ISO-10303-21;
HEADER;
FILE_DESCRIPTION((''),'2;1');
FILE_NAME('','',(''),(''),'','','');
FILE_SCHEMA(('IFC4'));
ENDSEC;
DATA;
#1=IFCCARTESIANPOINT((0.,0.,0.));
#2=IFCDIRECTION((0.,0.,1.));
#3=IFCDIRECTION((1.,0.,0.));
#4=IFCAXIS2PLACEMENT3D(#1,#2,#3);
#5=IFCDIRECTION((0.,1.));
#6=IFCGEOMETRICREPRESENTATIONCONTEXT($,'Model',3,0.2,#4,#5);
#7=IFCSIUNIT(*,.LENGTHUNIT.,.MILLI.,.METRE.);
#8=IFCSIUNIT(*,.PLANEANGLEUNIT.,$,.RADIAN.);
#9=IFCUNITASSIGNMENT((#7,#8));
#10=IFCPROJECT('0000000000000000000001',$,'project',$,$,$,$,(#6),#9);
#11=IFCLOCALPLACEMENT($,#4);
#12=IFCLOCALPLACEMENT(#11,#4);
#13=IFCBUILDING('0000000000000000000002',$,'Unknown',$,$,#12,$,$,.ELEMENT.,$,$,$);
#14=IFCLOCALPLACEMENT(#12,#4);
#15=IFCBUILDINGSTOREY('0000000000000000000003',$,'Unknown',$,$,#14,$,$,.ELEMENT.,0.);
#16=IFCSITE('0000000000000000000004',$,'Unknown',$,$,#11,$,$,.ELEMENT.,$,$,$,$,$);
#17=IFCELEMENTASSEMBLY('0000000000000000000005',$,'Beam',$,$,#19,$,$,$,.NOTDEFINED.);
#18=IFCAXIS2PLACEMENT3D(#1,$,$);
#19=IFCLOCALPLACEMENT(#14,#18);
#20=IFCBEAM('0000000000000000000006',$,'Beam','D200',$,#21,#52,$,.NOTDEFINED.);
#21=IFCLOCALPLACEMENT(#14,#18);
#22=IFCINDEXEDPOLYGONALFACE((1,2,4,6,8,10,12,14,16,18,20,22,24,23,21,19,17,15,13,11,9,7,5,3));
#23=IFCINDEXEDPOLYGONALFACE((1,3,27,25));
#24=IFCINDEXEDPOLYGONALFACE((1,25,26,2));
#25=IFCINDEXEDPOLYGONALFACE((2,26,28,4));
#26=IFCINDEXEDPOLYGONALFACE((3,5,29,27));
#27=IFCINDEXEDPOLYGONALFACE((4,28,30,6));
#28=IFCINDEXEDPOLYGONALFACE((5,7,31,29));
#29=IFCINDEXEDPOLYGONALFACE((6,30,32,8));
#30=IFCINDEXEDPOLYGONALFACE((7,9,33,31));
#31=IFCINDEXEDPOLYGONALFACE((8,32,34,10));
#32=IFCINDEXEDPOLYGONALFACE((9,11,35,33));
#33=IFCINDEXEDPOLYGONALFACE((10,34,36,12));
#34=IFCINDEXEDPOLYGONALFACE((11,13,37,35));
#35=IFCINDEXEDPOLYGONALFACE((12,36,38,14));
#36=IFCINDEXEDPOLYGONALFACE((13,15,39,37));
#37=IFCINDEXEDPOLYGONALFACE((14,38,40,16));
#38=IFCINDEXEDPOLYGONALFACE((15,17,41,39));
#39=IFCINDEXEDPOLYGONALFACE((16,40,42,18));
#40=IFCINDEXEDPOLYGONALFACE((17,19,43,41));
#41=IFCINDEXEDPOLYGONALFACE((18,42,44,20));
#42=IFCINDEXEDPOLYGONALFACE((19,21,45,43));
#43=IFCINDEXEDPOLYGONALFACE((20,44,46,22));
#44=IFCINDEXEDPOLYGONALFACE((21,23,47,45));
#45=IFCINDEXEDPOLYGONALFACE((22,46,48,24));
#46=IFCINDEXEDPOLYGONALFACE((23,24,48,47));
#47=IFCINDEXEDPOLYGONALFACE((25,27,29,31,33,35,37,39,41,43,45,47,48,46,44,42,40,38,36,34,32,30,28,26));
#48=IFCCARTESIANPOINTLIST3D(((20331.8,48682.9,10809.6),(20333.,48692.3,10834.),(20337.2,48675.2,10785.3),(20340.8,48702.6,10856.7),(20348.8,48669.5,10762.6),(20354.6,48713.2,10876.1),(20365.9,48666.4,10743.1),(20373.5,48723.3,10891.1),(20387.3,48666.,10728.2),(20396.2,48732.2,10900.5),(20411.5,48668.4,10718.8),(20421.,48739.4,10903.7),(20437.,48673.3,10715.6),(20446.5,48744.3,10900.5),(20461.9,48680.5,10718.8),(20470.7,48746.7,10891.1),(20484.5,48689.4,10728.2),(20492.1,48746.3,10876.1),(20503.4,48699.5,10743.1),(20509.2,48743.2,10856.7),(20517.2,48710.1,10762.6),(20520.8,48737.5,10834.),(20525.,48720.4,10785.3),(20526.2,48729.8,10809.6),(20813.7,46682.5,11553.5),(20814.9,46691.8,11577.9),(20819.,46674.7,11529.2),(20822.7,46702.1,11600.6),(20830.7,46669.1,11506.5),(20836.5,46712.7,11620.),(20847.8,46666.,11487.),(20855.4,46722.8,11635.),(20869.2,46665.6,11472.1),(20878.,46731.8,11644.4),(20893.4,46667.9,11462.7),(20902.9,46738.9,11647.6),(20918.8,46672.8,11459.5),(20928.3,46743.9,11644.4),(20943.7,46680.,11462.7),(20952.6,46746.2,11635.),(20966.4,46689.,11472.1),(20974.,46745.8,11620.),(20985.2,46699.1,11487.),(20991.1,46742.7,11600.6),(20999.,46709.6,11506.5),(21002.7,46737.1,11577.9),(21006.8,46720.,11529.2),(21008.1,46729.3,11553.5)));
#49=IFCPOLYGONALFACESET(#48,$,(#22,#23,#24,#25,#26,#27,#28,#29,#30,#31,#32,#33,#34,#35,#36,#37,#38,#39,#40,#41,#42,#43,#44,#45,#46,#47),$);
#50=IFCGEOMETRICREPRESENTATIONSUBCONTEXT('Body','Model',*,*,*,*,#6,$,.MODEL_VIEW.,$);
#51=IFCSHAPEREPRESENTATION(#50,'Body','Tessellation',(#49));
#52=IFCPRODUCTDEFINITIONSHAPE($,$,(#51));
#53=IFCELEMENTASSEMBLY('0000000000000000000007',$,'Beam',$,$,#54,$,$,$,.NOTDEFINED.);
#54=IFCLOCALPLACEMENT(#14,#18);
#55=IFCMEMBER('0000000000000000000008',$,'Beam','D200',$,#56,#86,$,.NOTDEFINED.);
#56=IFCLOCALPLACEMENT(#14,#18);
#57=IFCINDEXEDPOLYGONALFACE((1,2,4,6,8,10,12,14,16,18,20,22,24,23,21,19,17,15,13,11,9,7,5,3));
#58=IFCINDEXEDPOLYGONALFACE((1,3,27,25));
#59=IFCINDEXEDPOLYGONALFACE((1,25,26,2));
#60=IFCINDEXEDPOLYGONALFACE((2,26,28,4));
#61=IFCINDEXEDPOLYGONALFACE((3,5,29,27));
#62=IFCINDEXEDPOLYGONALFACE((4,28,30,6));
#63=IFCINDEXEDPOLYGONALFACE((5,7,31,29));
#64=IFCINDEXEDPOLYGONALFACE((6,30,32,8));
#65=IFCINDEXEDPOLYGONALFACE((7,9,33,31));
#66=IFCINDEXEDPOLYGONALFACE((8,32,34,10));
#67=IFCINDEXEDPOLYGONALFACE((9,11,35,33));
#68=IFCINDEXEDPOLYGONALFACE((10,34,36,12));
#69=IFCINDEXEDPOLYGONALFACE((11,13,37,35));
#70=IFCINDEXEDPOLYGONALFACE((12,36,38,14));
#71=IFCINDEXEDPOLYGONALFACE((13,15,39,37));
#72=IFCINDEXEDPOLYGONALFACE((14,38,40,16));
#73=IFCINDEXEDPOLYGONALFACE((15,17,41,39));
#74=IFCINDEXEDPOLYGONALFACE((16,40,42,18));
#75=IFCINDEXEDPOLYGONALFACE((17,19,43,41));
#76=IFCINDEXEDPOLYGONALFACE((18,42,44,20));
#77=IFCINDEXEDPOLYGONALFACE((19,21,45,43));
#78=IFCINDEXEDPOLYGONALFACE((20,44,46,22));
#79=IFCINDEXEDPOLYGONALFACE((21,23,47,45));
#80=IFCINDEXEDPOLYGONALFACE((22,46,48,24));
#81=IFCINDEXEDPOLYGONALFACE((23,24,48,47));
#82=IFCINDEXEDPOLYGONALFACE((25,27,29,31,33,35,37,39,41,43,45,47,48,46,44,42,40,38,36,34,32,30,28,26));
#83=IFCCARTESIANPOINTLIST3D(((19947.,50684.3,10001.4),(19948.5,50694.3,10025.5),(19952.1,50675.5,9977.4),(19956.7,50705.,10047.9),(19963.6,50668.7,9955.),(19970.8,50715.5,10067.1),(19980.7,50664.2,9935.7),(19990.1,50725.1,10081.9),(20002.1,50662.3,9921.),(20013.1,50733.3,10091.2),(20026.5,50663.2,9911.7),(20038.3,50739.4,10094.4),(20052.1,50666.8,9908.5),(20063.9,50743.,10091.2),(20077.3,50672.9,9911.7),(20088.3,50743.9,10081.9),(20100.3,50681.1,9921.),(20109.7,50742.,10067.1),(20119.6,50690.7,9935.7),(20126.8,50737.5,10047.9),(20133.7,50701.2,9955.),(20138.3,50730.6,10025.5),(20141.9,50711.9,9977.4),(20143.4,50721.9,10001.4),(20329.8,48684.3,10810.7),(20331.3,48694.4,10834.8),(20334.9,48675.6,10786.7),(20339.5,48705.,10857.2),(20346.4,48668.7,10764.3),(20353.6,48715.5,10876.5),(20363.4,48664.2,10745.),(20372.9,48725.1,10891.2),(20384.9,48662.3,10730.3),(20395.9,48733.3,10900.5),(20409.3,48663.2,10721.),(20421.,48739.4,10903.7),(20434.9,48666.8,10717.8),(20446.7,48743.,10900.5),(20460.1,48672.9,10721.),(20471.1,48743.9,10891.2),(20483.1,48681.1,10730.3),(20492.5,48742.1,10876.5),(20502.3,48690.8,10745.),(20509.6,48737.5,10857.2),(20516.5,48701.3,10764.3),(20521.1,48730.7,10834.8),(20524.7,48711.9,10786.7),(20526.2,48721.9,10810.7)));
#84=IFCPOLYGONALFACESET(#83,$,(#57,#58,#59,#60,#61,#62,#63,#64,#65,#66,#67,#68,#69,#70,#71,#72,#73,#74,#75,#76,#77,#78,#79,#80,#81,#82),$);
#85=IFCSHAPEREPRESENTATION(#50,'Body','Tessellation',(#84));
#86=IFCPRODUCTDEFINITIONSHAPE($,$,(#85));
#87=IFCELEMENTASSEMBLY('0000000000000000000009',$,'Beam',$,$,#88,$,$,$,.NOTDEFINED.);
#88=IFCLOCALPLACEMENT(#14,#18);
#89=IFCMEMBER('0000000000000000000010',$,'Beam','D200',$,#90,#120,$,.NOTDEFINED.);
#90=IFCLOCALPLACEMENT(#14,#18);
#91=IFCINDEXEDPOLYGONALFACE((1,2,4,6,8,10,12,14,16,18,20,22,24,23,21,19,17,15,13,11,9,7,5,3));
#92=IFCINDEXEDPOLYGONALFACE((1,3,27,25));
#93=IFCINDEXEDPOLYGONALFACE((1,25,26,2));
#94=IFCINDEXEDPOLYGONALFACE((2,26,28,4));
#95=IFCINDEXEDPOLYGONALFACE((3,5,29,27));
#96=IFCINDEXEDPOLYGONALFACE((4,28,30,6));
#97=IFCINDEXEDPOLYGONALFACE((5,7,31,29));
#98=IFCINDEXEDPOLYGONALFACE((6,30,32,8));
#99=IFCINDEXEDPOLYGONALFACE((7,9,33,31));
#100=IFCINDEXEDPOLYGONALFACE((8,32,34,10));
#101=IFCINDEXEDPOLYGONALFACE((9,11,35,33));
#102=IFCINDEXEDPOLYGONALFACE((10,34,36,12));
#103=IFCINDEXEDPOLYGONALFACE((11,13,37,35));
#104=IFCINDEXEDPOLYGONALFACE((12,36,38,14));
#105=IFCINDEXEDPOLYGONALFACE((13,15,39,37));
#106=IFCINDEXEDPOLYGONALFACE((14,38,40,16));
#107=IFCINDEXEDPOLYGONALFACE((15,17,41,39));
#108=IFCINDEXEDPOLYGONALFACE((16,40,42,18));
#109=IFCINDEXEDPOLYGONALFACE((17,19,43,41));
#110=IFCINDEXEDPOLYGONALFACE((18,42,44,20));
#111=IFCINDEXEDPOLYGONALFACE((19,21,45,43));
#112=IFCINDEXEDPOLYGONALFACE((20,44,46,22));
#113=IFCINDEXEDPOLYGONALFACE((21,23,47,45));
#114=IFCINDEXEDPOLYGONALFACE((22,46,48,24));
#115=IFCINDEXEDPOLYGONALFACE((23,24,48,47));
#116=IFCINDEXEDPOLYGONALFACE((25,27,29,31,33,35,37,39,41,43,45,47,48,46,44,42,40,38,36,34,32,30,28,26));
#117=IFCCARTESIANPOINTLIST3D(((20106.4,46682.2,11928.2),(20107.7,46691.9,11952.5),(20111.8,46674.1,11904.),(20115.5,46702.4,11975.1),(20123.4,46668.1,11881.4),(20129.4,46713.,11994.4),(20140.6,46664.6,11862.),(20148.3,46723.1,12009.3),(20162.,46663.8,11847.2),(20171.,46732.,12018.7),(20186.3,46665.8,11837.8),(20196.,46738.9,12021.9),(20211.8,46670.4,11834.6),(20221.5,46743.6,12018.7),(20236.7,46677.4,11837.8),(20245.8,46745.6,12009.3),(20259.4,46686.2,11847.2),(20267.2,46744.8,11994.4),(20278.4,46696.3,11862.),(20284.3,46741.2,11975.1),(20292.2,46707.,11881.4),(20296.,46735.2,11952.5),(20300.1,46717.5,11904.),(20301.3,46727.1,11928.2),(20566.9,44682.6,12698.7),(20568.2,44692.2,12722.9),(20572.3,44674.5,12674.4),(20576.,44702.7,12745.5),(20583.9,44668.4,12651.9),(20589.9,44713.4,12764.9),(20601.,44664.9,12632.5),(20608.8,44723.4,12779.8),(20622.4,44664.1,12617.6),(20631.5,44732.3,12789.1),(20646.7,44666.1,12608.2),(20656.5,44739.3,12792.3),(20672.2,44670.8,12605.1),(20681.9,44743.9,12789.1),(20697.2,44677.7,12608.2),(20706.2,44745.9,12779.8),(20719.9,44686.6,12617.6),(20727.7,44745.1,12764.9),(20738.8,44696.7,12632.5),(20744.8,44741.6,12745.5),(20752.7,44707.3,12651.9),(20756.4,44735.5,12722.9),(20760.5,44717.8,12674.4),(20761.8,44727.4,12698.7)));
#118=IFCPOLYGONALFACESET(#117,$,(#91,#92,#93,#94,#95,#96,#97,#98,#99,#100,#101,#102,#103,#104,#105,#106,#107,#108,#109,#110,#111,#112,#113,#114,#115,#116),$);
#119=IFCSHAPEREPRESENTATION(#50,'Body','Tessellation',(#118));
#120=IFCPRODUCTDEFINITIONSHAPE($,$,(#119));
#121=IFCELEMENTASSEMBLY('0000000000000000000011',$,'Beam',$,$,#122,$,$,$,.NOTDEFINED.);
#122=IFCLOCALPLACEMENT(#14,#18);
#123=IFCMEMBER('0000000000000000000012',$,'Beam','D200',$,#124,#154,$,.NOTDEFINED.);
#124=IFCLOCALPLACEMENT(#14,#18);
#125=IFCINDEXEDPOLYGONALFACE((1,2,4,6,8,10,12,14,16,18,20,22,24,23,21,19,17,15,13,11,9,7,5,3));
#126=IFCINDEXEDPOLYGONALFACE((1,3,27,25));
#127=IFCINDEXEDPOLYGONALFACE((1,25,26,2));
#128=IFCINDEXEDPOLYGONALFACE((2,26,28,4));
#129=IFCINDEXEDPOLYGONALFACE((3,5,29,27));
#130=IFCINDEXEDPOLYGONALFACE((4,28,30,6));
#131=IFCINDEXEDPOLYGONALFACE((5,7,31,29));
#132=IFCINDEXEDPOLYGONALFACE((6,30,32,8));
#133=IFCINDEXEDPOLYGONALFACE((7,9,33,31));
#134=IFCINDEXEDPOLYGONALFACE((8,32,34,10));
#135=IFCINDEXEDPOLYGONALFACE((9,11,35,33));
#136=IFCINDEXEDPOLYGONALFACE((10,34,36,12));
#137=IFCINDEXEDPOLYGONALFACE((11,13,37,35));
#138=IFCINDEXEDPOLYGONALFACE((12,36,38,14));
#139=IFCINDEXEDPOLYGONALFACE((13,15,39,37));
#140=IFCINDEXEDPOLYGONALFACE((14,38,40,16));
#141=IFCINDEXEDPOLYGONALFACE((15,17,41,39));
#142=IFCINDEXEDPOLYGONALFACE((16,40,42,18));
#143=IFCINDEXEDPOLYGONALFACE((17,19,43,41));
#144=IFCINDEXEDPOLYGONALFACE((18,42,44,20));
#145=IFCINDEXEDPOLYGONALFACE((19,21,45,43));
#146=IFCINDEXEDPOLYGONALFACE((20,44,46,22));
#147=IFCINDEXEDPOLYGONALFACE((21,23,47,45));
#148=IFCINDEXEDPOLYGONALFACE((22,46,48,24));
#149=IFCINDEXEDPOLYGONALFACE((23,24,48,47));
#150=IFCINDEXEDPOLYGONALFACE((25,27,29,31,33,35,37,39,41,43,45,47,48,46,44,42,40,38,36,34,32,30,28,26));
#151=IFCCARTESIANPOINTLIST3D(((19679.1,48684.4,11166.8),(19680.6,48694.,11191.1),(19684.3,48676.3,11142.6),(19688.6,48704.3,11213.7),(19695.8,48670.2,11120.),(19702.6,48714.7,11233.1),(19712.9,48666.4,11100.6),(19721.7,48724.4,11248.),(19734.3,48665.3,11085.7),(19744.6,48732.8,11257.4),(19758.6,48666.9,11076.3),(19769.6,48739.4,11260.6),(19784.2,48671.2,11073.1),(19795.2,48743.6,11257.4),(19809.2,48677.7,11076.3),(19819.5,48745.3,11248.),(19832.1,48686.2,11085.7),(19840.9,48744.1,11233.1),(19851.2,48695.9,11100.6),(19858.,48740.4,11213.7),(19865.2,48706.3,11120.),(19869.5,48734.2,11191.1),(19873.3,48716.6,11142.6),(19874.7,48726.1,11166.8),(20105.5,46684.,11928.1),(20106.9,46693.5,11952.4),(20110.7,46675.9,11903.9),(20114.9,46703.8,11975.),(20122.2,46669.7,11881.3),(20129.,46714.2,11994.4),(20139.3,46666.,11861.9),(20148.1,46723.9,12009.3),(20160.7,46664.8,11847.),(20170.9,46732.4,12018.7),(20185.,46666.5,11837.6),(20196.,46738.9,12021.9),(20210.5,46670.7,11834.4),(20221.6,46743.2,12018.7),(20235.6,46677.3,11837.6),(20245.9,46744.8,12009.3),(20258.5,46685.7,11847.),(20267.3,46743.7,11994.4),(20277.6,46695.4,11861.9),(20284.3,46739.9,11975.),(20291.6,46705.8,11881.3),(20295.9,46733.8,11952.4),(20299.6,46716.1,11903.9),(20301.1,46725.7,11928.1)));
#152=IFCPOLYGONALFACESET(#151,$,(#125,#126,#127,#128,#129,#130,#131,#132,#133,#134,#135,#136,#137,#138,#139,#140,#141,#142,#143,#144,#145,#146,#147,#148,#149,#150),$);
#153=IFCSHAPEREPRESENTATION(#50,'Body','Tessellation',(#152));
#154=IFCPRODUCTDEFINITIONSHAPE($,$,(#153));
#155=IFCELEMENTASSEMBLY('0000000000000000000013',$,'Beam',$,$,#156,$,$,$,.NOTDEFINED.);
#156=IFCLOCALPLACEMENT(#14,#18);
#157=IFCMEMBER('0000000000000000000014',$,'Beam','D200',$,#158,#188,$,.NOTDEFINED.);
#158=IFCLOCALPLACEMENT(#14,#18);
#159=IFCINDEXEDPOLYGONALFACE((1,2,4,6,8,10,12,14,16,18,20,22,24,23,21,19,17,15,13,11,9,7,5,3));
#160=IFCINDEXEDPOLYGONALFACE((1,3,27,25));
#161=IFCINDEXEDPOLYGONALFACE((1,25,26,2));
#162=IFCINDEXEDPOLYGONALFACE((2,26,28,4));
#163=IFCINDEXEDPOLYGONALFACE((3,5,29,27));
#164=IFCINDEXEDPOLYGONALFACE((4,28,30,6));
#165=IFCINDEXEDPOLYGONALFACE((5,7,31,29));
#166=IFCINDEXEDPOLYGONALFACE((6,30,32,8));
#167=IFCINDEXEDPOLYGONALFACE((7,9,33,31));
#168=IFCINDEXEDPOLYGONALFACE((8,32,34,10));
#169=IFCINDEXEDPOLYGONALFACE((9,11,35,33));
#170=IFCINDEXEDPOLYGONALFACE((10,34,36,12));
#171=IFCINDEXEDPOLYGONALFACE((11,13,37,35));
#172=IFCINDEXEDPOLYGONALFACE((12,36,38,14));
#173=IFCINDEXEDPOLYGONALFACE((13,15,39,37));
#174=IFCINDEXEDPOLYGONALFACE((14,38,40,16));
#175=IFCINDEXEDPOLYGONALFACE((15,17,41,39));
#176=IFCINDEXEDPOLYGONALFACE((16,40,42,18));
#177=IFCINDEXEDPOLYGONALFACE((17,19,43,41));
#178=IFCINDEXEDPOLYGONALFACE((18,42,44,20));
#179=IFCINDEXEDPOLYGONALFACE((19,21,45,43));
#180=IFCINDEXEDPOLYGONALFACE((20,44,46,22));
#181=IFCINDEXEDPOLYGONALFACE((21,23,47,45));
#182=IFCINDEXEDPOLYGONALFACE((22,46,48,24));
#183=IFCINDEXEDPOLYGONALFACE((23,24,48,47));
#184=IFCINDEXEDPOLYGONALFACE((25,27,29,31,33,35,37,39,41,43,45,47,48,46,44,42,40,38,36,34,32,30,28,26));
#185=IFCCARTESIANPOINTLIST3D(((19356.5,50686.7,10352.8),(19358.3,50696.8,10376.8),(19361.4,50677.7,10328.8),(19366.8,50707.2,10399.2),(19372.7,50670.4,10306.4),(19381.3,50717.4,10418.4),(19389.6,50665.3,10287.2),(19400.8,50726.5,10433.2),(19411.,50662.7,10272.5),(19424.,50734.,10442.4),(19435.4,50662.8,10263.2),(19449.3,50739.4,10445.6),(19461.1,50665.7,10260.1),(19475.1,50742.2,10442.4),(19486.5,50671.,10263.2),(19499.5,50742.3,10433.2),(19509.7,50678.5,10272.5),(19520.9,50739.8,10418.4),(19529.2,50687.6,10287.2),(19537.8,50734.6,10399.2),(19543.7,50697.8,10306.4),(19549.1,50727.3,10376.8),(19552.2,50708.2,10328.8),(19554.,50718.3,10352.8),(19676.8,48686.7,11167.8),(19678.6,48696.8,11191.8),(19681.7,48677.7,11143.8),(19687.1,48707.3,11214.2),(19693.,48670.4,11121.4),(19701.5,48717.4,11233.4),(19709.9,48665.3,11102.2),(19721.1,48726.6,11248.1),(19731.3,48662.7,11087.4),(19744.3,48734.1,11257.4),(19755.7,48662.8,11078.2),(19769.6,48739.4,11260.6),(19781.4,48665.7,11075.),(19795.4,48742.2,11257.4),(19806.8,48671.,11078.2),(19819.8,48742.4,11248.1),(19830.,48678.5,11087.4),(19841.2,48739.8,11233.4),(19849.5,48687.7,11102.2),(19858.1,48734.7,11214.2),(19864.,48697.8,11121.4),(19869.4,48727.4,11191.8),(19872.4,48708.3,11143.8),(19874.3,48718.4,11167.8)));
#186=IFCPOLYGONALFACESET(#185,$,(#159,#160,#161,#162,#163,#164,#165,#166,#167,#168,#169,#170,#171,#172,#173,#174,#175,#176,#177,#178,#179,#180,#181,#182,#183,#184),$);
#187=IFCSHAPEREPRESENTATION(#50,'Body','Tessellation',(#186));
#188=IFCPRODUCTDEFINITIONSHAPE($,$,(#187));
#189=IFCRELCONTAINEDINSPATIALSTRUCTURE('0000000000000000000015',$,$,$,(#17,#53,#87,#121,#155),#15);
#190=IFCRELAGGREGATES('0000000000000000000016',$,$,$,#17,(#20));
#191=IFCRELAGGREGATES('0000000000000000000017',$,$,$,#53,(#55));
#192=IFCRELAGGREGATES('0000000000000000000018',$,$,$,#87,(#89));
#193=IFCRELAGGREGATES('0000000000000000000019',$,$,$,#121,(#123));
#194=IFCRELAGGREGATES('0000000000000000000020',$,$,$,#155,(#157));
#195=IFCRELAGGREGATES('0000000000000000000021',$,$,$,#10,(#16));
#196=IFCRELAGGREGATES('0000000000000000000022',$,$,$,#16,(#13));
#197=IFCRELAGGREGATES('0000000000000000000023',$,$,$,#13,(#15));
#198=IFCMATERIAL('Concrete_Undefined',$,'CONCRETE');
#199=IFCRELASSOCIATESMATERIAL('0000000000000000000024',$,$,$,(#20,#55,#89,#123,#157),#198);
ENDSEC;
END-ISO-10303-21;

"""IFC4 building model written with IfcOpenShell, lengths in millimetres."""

from ifc_helpers import new_model, si_unit, direction, frame, origin_with_axes, place, context, subcontext, project, spatial, line, indexed_curve, outline, extrude, material, element, aggregate, save


model = new_model("IFC4")

# Units and contexts
model_context = context("Model", 3, precision=0.2, world=origin_with_axes(), true_north=direction((0.0, 1.0)))
body_context = subcontext(model_context, "Body", "Model", "MODEL_VIEW")
ifc_project = project(units=[si_unit("LENGTHUNIT", "METRE", prefix="MILLI"), si_unit("PLANEANGLEUNIT", "RADIAN")], contexts=[model_context])

# Site, building, storey
site_placement = place(None, origin_with_axes())
site = spatial("IfcSite", under=ifc_project, at=site_placement, Name="Unknown", CompositionType="ELEMENT")
building_placement = place(site_placement, origin_with_axes())
building = spatial("IfcBuilding", under=site, at=building_placement, Name="Unknown", CompositionType="ELEMENT")
storey_placement = place(building_placement, origin_with_axes())
storey = spatial("IfcBuildingStorey", under=building, at=storey_placement, Name="Unknown", CompositionType="ELEMENT", Elevation=0.0)

# Element assembly, beam
assembly_1_placement = place(storey_placement, frame((20429.0, 48706.3, 10809.6), z_axis=(-0.972193, -0.23418, 0.0), x_axis=(0.220229, -0.914277, 0.339995)))
assembly_1 = element("IfcElementAssembly", 1, at=assembly_1_placement, inside=storey, Name="Beam", PredefinedType="NOTDEFINED")
ifc_material = material(Name="Concrete_Undefined", Category="CONCRETE")
beam_1_placement = place(assembly_1_placement, origin_with_axes())
beam_1 = element("IfcBeam", 2, at=beam_1_placement, material=ifc_material, Name="Beam", Description="D200", PredefinedType="NOTDEFINED", context=body_context, shape_type="SolidModel", body=[
    extrude(outline(indexed_curve([(100.0, 0.0), (96.6, 25.9), (86.6, 50.0), (70.7, 70.7), (50.0, 86.6), (25.9, 96.6), (0.0, 100.0), (-25.9, 96.6), (-50.0, 86.6), (-70.7, 70.7), (-86.6, 50.0), (-96.6, 25.9), (-100.0, 0.0), (-96.6, -25.9), (-86.6, -50.0), (-70.7, -70.7), (-50.0, -86.6), (-25.9, -96.6), (0.0, -100.0), (25.9, -96.6), (50.0, -86.6), (70.7, -70.7), (86.6, -50.0), (96.6, -25.9)], segments=[line(1, 2, 3, 4, 5, 6, 7, 8, 9, 10, 11, 12, 13, 14, 15, 16, 17, 18, 19, 20, 21, 22, 23, 24, 1)])), frame((0.0, 0.0, 0.0), z_axis=(-1.0, 0.0, 0.0), x_axis=(0.0, 0.0, 1.0)), (0.0, 0.0, -1.0), 2188.0),
])
aggregate(assembly_1, [beam_1])

# Element assemblies, members
assembly_2_placement = place(storey_placement, frame((20045.2, 50703.1, 10001.4), z_axis=(-0.982173, -0.187981, 0.0), x_axis=(0.174689, -0.912725, 0.369346)))
assembly_2 = element("IfcElementAssembly", 3, at=assembly_2_placement, inside=storey, Name="Beam", PredefinedType="NOTDEFINED")
member_1_placement = place(assembly_2_placement, origin_with_axes())
member_1 = element("IfcMember", 4, at=member_1_placement, material=ifc_material, Name="Beam", Description="D200", PredefinedType="NOTDEFINED", context=body_context, shape_type="SolidModel", body=[
    extrude(outline(indexed_curve([(100.0, 0.0), (96.6, 25.9), (86.6, 50.0), (70.7, 70.7), (50.0, 86.6), (25.9, 96.6), (0.0, 100.0), (-25.9, 96.6), (-50.0, 86.6), (-70.7, 70.7), (-86.6, 50.0), (-96.6, 25.9), (-100.0, 0.0), (-96.6, -25.9), (-86.6, -50.0), (-70.7, -70.7), (-50.0, -86.6), (-25.9, -96.6), (0.0, -100.0), (25.9, -96.6), (50.0, -86.6), (70.7, -70.7), (86.6, -50.0), (96.6, -25.9)], segments=[line(1, 2, 3, 4, 5, 6, 7, 8, 9, 10, 11, 12, 13, 14, 15, 16, 17, 18, 19, 20, 21, 22, 23, 24, 1)])), frame((0.0, 0.0, 0.0), z_axis=(-1.0, 0.0, 0.0), x_axis=(0.0, 0.0, 1.0)), (0.0, 0.0, -1.0), 2191.2),
])
aggregate(assembly_2, [member_1])
assembly_3_placement = place(storey_placement, frame((20203.9, 46704.7, 11928.2), z_axis=(-0.974499, -0.224392, 0.0), x_axis=(0.210073, -0.912315, 0.351498)))
assembly_3 = element("IfcElementAssembly", 5, at=assembly_3_placement, inside=storey, Name="Beam", PredefinedType="NOTDEFINED")
member_2_placement = place(assembly_3_placement, origin_with_axes())
member_2 = element("IfcMember", 6, at=member_2_placement, material=ifc_material, Name="Beam", Description="D200", PredefinedType="NOTDEFINED", context=body_context, shape_type="SolidModel", body=[
    extrude(outline(indexed_curve([(100.0, 0.0), (96.6, 25.9), (86.6, 50.0), (70.7, 70.7), (50.0, 86.6), (25.9, 96.6), (0.0, 100.0), (-25.9, 96.6), (-50.0, 86.6), (-70.7, 70.7), (-86.6, 50.0), (-96.6, 25.9), (-100.0, 0.0), (-96.6, -25.9), (-86.6, -50.0), (-70.7, -70.7), (-50.0, -86.6), (-25.9, -96.6), (0.0, -100.0), (25.9, -96.6), (50.0, -86.6), (70.7, -70.7), (86.6, -50.0), (96.6, -25.9)], segments=[line(1, 2, 3, 4, 5, 6, 7, 8, 9, 10, 11, 12, 13, 14, 15, 16, 17, 18, 19, 20, 21, 22, 23, 24, 1)])), frame((0.0, 0.0, 0.0), z_axis=(-1.0, 0.0, 0.0), x_axis=(0.0, 0.0, 1.0)), (0.0, 0.0, -1.0), 2191.9),
])
aggregate(assembly_3, [member_2])
assembly_4_placement = place(storey_placement, frame((19776.9, 48705.3, 11166.8), z_axis=(-0.978034, -0.208448, 0.0), x_axis=(0.195355, -0.916601, 0.348824)))
assembly_4 = element("IfcElementAssembly", 7, at=assembly_4_placement, inside=storey, Name="Beam", PredefinedType="NOTDEFINED")
member_3_placement = place(assembly_4_placement, origin_with_axes())
member_3 = element("IfcMember", 8, at=member_3_placement, material=ifc_material, Name="Beam", Description="D200", PredefinedType="NOTDEFINED", context=body_context, shape_type="SolidModel", body=[
    extrude(outline(indexed_curve([(100.0, 0.0), (96.6, 25.9), (86.6, 50.0), (70.7, 70.7), (50.0, 86.6), (25.9, 96.6), (0.0, 100.0), (-25.9, 96.6), (-50.0, 86.6), (-70.7, 70.7), (-86.6, 50.0), (-96.6, 25.9), (-100.0, 0.0), (-96.6, -25.9), (-86.6, -50.0), (-70.7, -70.7), (-50.0, -86.6), (-25.9, -96.6), (0.0, -100.0), (25.9, -96.6), (50.0, -86.6), (70.7, -70.7), (86.6, -50.0), (96.6, -25.9)], segments=[line(1, 2, 3, 4, 5, 6, 7, 8, 9, 10, 11, 12, 13, 14, 15, 16, 17, 18, 19, 20, 21, 22, 23, 24, 1)])), frame((0.0, 0.0, 0.0), z_axis=(-1.0, 0.0, 0.0), x_axis=(0.0, 0.0, 1.0)), (0.0, 0.0, -1.0), 2182.5),
])
aggregate(assembly_4, [member_3])
assembly_5_placement = place(storey_placement, frame((19455.2, 50702.5, 10352.8), z_axis=(-0.987417, -0.158136, 0.0), x_axis=(0.146706, -0.916047, 0.373277)))
assembly_5 = element("IfcElementAssembly", 9, at=assembly_5_placement, inside=storey, Name="Beam", PredefinedType="NOTDEFINED")
member_4_placement = place(assembly_5_placement, origin_with_axes())
member_4 = element("IfcMember", 10, at=member_4_placement, material=ifc_material, Name="Beam", Description="D200", PredefinedType="NOTDEFINED", context=body_context, shape_type="SolidModel", body=[
    extrude(outline(indexed_curve([(100.0, 0.0), (96.6, 25.9), (86.6, 50.0), (70.7, 70.7), (50.0, 86.6), (25.9, 96.6), (0.0, 100.0), (-25.9, 96.6), (-50.0, 86.6), (-70.7, 70.7), (-86.6, 50.0), (-96.6, 25.9), (-100.0, 0.0), (-96.6, -25.9), (-86.6, -50.0), (-70.7, -70.7), (-50.0, -86.6), (-25.9, -96.6), (0.0, -100.0), (25.9, -96.6), (50.0, -86.6), (70.7, -70.7), (86.6, -50.0), (96.6, -25.9)], segments=[line(1, 2, 3, 4, 5, 6, 7, 8, 9, 10, 11, 12, 13, 14, 15, 16, 17, 18, 19, 20, 21, 22, 23, 24, 1)])), frame((0.0, 0.0, 0.0), z_axis=(-1.0, 0.0, 0.0), x_axis=(0.0, 0.0, 1.0)), (0.0, 0.0, -1.0), 2183.3),
])
aggregate(assembly_5, [member_4])

save(model, "model.ifc")
